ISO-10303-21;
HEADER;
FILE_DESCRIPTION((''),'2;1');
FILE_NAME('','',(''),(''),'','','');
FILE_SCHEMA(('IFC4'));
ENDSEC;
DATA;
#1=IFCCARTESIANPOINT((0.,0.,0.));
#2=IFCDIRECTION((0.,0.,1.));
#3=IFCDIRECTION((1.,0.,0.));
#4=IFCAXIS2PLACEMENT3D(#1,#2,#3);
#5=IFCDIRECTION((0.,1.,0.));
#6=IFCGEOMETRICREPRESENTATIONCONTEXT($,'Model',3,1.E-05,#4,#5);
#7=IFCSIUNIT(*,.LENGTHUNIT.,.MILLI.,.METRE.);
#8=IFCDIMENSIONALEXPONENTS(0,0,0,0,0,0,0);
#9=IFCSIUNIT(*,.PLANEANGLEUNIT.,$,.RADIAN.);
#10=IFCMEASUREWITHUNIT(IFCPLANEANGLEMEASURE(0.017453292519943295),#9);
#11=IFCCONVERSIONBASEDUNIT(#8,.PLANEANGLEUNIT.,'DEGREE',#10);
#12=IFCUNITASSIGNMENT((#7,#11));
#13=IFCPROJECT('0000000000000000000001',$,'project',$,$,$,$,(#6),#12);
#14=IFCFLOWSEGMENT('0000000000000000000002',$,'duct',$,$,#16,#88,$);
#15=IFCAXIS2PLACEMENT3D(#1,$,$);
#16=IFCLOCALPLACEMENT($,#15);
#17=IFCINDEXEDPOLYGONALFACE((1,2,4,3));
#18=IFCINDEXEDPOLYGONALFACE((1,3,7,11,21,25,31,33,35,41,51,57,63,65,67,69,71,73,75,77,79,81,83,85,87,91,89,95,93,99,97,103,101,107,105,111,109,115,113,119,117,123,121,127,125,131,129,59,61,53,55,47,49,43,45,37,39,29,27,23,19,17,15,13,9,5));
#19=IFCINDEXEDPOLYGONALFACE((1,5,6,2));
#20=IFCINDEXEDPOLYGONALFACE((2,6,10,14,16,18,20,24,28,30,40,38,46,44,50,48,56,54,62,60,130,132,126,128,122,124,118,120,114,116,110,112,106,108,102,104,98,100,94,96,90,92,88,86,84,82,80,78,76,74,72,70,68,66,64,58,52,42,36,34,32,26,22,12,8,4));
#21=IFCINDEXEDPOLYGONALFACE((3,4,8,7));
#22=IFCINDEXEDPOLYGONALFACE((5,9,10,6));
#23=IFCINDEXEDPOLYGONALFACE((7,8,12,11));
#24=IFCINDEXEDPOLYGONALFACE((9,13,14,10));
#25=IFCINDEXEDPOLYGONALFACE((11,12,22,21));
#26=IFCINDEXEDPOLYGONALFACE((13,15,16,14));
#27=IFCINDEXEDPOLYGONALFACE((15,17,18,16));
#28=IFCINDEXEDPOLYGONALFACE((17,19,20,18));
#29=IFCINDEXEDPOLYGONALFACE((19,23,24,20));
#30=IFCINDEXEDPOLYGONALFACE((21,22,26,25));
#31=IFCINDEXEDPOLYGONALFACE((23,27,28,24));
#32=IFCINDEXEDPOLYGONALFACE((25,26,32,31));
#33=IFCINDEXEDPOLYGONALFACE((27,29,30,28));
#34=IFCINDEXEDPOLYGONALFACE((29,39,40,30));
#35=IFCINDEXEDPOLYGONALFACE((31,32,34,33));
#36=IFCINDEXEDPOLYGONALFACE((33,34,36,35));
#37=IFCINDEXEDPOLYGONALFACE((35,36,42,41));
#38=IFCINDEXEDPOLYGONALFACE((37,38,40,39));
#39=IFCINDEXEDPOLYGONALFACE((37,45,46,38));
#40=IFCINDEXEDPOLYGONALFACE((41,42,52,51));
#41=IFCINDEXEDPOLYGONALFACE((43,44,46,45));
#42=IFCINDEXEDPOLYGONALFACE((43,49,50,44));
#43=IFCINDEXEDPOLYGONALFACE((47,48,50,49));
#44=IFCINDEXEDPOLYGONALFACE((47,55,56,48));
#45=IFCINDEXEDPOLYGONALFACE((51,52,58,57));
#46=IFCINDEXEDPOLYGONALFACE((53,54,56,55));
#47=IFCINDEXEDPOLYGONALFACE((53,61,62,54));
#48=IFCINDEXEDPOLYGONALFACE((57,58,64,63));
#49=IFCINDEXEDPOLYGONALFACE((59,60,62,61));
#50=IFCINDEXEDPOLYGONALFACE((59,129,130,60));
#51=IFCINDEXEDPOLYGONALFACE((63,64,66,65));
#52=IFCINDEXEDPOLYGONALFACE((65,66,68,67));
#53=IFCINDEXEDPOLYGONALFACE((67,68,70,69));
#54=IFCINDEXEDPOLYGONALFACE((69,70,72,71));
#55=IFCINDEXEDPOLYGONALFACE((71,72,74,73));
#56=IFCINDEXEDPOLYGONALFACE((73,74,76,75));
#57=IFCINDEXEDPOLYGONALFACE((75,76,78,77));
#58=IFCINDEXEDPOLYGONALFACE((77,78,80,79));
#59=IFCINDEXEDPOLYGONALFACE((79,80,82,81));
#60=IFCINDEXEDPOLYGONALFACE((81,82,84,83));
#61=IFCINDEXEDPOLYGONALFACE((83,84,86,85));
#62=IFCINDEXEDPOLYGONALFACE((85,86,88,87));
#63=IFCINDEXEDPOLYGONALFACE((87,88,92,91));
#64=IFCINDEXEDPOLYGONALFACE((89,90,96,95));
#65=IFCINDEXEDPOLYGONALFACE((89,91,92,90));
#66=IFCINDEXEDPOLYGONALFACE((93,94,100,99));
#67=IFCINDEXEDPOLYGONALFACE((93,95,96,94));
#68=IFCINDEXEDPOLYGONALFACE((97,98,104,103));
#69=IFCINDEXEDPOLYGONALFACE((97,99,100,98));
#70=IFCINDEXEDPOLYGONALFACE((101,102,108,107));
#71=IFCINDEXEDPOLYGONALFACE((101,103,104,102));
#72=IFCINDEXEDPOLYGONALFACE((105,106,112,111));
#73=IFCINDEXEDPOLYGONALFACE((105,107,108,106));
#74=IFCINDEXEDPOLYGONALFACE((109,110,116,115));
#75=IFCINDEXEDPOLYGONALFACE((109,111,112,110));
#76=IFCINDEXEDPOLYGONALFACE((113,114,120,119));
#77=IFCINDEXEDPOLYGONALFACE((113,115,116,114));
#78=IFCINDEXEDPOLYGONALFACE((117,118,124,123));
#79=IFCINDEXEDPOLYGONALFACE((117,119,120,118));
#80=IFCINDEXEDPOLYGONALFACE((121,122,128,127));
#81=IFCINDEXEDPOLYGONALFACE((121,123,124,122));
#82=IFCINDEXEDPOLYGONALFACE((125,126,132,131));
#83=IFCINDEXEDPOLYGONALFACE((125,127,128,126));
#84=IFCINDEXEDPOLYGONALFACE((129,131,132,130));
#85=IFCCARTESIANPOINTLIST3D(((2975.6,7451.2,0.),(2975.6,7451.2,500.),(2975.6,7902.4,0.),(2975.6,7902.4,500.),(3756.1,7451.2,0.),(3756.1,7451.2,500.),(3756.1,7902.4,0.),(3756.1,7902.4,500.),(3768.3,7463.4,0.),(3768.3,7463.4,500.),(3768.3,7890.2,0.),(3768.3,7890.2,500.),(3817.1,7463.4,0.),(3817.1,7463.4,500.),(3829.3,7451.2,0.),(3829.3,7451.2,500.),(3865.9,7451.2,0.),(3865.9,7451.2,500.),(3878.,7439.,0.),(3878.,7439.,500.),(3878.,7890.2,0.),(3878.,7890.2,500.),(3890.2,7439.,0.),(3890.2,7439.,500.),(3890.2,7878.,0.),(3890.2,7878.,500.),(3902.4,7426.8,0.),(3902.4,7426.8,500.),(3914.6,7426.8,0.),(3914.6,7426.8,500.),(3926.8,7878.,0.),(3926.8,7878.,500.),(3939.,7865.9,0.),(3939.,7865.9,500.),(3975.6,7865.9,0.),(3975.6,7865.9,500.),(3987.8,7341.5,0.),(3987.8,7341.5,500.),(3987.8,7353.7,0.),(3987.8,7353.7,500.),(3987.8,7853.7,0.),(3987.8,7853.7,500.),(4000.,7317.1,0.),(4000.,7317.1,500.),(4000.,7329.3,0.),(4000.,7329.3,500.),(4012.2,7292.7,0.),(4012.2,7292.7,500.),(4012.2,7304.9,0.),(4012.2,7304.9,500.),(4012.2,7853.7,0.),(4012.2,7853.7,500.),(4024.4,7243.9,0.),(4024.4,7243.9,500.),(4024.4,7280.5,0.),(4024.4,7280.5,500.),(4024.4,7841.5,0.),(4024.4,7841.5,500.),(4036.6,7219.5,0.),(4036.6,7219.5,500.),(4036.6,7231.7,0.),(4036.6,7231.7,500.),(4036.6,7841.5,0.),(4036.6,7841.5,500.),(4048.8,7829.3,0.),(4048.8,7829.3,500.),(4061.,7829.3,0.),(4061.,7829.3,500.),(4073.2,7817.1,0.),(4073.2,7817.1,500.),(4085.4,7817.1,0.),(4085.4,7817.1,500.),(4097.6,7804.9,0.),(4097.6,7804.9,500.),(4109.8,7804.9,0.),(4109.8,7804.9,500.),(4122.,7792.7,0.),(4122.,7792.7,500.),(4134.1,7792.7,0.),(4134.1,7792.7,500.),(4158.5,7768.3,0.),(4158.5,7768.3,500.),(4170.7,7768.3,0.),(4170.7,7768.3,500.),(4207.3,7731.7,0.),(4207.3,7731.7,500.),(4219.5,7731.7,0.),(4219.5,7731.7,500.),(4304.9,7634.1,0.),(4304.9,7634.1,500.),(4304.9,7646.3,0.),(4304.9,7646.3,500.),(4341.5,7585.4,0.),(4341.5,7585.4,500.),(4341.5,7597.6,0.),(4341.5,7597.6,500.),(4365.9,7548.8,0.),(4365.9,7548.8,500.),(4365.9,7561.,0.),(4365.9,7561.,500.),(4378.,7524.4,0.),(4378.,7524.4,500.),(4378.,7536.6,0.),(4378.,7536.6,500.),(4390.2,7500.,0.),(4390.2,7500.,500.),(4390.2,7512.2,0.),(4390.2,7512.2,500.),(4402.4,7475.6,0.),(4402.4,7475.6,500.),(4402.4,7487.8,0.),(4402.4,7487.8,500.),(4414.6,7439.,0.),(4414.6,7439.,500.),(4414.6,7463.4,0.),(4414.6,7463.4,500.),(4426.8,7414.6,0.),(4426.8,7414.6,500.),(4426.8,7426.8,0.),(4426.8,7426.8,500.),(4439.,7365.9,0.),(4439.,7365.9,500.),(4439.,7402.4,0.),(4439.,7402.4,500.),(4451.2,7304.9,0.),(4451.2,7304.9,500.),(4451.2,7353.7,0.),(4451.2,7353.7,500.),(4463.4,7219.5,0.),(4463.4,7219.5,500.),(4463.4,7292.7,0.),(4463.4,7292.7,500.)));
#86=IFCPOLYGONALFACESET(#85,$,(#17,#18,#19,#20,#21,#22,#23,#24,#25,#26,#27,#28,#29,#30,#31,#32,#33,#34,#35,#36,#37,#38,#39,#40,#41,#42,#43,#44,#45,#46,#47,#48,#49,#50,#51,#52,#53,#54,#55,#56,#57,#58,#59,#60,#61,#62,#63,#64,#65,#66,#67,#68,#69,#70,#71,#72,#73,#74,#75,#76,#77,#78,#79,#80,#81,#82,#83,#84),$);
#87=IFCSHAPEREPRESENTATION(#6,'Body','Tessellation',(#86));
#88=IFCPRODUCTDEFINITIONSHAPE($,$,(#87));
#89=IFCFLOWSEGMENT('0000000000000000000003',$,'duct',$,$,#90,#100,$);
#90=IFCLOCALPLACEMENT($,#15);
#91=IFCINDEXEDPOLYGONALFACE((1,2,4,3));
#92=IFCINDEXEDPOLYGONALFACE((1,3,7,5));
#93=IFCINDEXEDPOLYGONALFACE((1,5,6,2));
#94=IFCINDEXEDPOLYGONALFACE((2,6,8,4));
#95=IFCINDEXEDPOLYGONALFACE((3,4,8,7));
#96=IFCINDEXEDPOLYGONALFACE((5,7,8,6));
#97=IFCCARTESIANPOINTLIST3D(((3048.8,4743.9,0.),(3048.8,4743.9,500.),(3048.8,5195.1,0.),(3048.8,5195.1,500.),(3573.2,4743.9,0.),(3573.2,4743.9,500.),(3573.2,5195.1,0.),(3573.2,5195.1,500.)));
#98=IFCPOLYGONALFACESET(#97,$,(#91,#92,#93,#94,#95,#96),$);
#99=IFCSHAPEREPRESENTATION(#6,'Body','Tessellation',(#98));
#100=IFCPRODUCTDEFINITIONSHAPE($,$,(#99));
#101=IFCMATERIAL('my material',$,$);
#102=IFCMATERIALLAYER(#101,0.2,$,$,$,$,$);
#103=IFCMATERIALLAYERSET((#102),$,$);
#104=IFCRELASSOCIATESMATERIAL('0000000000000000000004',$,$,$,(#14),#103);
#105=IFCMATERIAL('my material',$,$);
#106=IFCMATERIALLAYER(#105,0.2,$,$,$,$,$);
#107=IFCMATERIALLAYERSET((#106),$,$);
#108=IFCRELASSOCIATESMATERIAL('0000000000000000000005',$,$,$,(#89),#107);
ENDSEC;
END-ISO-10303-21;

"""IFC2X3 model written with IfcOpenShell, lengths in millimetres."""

from ifc_helpers import new_model, entity, si_unit, converted_unit, direction, origin_with_axes, place, context, project, polyline, outline, extrude, material, layer, layer_set, layer_usage, element, save


model = new_model("IFC2X3")

# Units and contexts
model_context = context("Model", 3, precision=1e-05, world=origin_with_axes(), true_north=direction((0.0, 1.0, 0.0)))
ifc_project = project(units=[si_unit("LENGTHUNIT", "METRE", prefix="MILLI"), converted_unit("PLANEANGLEUNIT", "DEGREE", entity("IfcPlaneAngleMeasure", 0.017453292519943295), si_unit("PLANEANGLEUNIT", "RADIAN"), dimensions=[0, 0, 0, 0, 0, 0, 0])], contexts=[model_context])

# Flow segments
ifc_material_1 = material(Name="my material")
ifc_layer_1 = layer(ifc_material_1, 0.2)
ifc_layer_set_1 = layer_set([ifc_layer_1])
ifc_layer_usage_1 = layer_usage(ifc_layer_set_1, "AXIS2", "POSITIVE", -0.1)
flow_segment_1_placement = place(None, origin_with_axes())
element("IfcFlowSegment", 1, at=flow_segment_1_placement, material=ifc_layer_usage_1, Name="duct", context=model_context, shape_type="SweptSolid", body=[
    extrude(outline(polyline([(2975.6, 7451.2), (3756.1, 7451.2), (3768.3, 7463.4), (3817.1, 7463.4), (3829.3, 7451.2), (3865.9, 7451.2), (3878.0, 7439.0), (3890.2, 7439.0), (3902.4, 7426.8), (3914.6, 7426.8), (3987.8, 7353.7), (3987.8, 7341.5), (4000.0, 7329.3), (4000.0, 7317.1), (4012.2, 7304.9), (4012.2, 7292.7), (4024.4, 7280.5), (4024.4, 7243.9), (4036.6, 7231.7), (4036.6, 7219.5), (4463.4, 7219.5), (4463.4, 7292.7), (4451.2, 7304.9), (4451.2, 7353.7), (4439.0, 7365.9), (4439.0, 7402.4), (4426.8, 7414.6), (4426.8, 7426.8), (4414.6, 7439.0), (4414.6, 7463.4), (4402.4, 7475.6), (4402.4, 7487.8), (4390.2, 7500.0), (4390.2, 7512.2), (4378.0, 7524.4), (4378.0, 7536.6), (4365.9, 7548.8), (4365.9, 7561.0), (4341.5, 7585.4), (4341.5, 7597.6), (4304.9, 7634.1), (4304.9, 7646.3), (4219.5, 7731.7), (4207.3, 7731.7), (4170.7, 7768.3), (4158.5, 7768.3), (4134.1, 7792.7), (4122.0, 7792.7), (4109.8, 7804.9), (4097.6, 7804.9), (4085.4, 7817.1), (4073.2, 7817.1), (4061.0, 7829.3), (4048.8, 7829.3), (4036.6, 7841.5), (4024.4, 7841.5), (4012.2, 7853.7), (3987.8, 7853.7), (3975.6, 7865.9), (3939.0, 7865.9), (3926.8, 7878.0), (3890.2, 7878.0), (3878.0, 7890.2), (3768.3, 7890.2), (3756.1, 7902.4), (2975.6, 7902.4), (2975.6, 7451.2)])), origin_with_axes(), (0.0, 0.0, 1.0), 500.0),
])
ifc_material_2 = material(Name="my material")
ifc_layer_2 = layer(ifc_material_2, 0.2)
ifc_layer_set_2 = layer_set([ifc_layer_2])
ifc_layer_usage_2 = layer_usage(ifc_layer_set_2, "AXIS2", "POSITIVE", -0.1)
flow_segment_2_placement = place(None, origin_with_axes())
element("IfcFlowSegment", 2, at=flow_segment_2_placement, material=ifc_layer_usage_2, Name="duct", context=model_context, shape_type="SweptSolid", body=[
    extrude(outline(polyline([(3048.8, 4743.9), (3573.2, 4743.9), (3573.2, 5195.1), (3048.8, 5195.1), (3048.8, 4743.9)])), origin_with_axes(), (0.0, 0.0, 1.0), 500.0),
])

save(model, "model.ifc")
